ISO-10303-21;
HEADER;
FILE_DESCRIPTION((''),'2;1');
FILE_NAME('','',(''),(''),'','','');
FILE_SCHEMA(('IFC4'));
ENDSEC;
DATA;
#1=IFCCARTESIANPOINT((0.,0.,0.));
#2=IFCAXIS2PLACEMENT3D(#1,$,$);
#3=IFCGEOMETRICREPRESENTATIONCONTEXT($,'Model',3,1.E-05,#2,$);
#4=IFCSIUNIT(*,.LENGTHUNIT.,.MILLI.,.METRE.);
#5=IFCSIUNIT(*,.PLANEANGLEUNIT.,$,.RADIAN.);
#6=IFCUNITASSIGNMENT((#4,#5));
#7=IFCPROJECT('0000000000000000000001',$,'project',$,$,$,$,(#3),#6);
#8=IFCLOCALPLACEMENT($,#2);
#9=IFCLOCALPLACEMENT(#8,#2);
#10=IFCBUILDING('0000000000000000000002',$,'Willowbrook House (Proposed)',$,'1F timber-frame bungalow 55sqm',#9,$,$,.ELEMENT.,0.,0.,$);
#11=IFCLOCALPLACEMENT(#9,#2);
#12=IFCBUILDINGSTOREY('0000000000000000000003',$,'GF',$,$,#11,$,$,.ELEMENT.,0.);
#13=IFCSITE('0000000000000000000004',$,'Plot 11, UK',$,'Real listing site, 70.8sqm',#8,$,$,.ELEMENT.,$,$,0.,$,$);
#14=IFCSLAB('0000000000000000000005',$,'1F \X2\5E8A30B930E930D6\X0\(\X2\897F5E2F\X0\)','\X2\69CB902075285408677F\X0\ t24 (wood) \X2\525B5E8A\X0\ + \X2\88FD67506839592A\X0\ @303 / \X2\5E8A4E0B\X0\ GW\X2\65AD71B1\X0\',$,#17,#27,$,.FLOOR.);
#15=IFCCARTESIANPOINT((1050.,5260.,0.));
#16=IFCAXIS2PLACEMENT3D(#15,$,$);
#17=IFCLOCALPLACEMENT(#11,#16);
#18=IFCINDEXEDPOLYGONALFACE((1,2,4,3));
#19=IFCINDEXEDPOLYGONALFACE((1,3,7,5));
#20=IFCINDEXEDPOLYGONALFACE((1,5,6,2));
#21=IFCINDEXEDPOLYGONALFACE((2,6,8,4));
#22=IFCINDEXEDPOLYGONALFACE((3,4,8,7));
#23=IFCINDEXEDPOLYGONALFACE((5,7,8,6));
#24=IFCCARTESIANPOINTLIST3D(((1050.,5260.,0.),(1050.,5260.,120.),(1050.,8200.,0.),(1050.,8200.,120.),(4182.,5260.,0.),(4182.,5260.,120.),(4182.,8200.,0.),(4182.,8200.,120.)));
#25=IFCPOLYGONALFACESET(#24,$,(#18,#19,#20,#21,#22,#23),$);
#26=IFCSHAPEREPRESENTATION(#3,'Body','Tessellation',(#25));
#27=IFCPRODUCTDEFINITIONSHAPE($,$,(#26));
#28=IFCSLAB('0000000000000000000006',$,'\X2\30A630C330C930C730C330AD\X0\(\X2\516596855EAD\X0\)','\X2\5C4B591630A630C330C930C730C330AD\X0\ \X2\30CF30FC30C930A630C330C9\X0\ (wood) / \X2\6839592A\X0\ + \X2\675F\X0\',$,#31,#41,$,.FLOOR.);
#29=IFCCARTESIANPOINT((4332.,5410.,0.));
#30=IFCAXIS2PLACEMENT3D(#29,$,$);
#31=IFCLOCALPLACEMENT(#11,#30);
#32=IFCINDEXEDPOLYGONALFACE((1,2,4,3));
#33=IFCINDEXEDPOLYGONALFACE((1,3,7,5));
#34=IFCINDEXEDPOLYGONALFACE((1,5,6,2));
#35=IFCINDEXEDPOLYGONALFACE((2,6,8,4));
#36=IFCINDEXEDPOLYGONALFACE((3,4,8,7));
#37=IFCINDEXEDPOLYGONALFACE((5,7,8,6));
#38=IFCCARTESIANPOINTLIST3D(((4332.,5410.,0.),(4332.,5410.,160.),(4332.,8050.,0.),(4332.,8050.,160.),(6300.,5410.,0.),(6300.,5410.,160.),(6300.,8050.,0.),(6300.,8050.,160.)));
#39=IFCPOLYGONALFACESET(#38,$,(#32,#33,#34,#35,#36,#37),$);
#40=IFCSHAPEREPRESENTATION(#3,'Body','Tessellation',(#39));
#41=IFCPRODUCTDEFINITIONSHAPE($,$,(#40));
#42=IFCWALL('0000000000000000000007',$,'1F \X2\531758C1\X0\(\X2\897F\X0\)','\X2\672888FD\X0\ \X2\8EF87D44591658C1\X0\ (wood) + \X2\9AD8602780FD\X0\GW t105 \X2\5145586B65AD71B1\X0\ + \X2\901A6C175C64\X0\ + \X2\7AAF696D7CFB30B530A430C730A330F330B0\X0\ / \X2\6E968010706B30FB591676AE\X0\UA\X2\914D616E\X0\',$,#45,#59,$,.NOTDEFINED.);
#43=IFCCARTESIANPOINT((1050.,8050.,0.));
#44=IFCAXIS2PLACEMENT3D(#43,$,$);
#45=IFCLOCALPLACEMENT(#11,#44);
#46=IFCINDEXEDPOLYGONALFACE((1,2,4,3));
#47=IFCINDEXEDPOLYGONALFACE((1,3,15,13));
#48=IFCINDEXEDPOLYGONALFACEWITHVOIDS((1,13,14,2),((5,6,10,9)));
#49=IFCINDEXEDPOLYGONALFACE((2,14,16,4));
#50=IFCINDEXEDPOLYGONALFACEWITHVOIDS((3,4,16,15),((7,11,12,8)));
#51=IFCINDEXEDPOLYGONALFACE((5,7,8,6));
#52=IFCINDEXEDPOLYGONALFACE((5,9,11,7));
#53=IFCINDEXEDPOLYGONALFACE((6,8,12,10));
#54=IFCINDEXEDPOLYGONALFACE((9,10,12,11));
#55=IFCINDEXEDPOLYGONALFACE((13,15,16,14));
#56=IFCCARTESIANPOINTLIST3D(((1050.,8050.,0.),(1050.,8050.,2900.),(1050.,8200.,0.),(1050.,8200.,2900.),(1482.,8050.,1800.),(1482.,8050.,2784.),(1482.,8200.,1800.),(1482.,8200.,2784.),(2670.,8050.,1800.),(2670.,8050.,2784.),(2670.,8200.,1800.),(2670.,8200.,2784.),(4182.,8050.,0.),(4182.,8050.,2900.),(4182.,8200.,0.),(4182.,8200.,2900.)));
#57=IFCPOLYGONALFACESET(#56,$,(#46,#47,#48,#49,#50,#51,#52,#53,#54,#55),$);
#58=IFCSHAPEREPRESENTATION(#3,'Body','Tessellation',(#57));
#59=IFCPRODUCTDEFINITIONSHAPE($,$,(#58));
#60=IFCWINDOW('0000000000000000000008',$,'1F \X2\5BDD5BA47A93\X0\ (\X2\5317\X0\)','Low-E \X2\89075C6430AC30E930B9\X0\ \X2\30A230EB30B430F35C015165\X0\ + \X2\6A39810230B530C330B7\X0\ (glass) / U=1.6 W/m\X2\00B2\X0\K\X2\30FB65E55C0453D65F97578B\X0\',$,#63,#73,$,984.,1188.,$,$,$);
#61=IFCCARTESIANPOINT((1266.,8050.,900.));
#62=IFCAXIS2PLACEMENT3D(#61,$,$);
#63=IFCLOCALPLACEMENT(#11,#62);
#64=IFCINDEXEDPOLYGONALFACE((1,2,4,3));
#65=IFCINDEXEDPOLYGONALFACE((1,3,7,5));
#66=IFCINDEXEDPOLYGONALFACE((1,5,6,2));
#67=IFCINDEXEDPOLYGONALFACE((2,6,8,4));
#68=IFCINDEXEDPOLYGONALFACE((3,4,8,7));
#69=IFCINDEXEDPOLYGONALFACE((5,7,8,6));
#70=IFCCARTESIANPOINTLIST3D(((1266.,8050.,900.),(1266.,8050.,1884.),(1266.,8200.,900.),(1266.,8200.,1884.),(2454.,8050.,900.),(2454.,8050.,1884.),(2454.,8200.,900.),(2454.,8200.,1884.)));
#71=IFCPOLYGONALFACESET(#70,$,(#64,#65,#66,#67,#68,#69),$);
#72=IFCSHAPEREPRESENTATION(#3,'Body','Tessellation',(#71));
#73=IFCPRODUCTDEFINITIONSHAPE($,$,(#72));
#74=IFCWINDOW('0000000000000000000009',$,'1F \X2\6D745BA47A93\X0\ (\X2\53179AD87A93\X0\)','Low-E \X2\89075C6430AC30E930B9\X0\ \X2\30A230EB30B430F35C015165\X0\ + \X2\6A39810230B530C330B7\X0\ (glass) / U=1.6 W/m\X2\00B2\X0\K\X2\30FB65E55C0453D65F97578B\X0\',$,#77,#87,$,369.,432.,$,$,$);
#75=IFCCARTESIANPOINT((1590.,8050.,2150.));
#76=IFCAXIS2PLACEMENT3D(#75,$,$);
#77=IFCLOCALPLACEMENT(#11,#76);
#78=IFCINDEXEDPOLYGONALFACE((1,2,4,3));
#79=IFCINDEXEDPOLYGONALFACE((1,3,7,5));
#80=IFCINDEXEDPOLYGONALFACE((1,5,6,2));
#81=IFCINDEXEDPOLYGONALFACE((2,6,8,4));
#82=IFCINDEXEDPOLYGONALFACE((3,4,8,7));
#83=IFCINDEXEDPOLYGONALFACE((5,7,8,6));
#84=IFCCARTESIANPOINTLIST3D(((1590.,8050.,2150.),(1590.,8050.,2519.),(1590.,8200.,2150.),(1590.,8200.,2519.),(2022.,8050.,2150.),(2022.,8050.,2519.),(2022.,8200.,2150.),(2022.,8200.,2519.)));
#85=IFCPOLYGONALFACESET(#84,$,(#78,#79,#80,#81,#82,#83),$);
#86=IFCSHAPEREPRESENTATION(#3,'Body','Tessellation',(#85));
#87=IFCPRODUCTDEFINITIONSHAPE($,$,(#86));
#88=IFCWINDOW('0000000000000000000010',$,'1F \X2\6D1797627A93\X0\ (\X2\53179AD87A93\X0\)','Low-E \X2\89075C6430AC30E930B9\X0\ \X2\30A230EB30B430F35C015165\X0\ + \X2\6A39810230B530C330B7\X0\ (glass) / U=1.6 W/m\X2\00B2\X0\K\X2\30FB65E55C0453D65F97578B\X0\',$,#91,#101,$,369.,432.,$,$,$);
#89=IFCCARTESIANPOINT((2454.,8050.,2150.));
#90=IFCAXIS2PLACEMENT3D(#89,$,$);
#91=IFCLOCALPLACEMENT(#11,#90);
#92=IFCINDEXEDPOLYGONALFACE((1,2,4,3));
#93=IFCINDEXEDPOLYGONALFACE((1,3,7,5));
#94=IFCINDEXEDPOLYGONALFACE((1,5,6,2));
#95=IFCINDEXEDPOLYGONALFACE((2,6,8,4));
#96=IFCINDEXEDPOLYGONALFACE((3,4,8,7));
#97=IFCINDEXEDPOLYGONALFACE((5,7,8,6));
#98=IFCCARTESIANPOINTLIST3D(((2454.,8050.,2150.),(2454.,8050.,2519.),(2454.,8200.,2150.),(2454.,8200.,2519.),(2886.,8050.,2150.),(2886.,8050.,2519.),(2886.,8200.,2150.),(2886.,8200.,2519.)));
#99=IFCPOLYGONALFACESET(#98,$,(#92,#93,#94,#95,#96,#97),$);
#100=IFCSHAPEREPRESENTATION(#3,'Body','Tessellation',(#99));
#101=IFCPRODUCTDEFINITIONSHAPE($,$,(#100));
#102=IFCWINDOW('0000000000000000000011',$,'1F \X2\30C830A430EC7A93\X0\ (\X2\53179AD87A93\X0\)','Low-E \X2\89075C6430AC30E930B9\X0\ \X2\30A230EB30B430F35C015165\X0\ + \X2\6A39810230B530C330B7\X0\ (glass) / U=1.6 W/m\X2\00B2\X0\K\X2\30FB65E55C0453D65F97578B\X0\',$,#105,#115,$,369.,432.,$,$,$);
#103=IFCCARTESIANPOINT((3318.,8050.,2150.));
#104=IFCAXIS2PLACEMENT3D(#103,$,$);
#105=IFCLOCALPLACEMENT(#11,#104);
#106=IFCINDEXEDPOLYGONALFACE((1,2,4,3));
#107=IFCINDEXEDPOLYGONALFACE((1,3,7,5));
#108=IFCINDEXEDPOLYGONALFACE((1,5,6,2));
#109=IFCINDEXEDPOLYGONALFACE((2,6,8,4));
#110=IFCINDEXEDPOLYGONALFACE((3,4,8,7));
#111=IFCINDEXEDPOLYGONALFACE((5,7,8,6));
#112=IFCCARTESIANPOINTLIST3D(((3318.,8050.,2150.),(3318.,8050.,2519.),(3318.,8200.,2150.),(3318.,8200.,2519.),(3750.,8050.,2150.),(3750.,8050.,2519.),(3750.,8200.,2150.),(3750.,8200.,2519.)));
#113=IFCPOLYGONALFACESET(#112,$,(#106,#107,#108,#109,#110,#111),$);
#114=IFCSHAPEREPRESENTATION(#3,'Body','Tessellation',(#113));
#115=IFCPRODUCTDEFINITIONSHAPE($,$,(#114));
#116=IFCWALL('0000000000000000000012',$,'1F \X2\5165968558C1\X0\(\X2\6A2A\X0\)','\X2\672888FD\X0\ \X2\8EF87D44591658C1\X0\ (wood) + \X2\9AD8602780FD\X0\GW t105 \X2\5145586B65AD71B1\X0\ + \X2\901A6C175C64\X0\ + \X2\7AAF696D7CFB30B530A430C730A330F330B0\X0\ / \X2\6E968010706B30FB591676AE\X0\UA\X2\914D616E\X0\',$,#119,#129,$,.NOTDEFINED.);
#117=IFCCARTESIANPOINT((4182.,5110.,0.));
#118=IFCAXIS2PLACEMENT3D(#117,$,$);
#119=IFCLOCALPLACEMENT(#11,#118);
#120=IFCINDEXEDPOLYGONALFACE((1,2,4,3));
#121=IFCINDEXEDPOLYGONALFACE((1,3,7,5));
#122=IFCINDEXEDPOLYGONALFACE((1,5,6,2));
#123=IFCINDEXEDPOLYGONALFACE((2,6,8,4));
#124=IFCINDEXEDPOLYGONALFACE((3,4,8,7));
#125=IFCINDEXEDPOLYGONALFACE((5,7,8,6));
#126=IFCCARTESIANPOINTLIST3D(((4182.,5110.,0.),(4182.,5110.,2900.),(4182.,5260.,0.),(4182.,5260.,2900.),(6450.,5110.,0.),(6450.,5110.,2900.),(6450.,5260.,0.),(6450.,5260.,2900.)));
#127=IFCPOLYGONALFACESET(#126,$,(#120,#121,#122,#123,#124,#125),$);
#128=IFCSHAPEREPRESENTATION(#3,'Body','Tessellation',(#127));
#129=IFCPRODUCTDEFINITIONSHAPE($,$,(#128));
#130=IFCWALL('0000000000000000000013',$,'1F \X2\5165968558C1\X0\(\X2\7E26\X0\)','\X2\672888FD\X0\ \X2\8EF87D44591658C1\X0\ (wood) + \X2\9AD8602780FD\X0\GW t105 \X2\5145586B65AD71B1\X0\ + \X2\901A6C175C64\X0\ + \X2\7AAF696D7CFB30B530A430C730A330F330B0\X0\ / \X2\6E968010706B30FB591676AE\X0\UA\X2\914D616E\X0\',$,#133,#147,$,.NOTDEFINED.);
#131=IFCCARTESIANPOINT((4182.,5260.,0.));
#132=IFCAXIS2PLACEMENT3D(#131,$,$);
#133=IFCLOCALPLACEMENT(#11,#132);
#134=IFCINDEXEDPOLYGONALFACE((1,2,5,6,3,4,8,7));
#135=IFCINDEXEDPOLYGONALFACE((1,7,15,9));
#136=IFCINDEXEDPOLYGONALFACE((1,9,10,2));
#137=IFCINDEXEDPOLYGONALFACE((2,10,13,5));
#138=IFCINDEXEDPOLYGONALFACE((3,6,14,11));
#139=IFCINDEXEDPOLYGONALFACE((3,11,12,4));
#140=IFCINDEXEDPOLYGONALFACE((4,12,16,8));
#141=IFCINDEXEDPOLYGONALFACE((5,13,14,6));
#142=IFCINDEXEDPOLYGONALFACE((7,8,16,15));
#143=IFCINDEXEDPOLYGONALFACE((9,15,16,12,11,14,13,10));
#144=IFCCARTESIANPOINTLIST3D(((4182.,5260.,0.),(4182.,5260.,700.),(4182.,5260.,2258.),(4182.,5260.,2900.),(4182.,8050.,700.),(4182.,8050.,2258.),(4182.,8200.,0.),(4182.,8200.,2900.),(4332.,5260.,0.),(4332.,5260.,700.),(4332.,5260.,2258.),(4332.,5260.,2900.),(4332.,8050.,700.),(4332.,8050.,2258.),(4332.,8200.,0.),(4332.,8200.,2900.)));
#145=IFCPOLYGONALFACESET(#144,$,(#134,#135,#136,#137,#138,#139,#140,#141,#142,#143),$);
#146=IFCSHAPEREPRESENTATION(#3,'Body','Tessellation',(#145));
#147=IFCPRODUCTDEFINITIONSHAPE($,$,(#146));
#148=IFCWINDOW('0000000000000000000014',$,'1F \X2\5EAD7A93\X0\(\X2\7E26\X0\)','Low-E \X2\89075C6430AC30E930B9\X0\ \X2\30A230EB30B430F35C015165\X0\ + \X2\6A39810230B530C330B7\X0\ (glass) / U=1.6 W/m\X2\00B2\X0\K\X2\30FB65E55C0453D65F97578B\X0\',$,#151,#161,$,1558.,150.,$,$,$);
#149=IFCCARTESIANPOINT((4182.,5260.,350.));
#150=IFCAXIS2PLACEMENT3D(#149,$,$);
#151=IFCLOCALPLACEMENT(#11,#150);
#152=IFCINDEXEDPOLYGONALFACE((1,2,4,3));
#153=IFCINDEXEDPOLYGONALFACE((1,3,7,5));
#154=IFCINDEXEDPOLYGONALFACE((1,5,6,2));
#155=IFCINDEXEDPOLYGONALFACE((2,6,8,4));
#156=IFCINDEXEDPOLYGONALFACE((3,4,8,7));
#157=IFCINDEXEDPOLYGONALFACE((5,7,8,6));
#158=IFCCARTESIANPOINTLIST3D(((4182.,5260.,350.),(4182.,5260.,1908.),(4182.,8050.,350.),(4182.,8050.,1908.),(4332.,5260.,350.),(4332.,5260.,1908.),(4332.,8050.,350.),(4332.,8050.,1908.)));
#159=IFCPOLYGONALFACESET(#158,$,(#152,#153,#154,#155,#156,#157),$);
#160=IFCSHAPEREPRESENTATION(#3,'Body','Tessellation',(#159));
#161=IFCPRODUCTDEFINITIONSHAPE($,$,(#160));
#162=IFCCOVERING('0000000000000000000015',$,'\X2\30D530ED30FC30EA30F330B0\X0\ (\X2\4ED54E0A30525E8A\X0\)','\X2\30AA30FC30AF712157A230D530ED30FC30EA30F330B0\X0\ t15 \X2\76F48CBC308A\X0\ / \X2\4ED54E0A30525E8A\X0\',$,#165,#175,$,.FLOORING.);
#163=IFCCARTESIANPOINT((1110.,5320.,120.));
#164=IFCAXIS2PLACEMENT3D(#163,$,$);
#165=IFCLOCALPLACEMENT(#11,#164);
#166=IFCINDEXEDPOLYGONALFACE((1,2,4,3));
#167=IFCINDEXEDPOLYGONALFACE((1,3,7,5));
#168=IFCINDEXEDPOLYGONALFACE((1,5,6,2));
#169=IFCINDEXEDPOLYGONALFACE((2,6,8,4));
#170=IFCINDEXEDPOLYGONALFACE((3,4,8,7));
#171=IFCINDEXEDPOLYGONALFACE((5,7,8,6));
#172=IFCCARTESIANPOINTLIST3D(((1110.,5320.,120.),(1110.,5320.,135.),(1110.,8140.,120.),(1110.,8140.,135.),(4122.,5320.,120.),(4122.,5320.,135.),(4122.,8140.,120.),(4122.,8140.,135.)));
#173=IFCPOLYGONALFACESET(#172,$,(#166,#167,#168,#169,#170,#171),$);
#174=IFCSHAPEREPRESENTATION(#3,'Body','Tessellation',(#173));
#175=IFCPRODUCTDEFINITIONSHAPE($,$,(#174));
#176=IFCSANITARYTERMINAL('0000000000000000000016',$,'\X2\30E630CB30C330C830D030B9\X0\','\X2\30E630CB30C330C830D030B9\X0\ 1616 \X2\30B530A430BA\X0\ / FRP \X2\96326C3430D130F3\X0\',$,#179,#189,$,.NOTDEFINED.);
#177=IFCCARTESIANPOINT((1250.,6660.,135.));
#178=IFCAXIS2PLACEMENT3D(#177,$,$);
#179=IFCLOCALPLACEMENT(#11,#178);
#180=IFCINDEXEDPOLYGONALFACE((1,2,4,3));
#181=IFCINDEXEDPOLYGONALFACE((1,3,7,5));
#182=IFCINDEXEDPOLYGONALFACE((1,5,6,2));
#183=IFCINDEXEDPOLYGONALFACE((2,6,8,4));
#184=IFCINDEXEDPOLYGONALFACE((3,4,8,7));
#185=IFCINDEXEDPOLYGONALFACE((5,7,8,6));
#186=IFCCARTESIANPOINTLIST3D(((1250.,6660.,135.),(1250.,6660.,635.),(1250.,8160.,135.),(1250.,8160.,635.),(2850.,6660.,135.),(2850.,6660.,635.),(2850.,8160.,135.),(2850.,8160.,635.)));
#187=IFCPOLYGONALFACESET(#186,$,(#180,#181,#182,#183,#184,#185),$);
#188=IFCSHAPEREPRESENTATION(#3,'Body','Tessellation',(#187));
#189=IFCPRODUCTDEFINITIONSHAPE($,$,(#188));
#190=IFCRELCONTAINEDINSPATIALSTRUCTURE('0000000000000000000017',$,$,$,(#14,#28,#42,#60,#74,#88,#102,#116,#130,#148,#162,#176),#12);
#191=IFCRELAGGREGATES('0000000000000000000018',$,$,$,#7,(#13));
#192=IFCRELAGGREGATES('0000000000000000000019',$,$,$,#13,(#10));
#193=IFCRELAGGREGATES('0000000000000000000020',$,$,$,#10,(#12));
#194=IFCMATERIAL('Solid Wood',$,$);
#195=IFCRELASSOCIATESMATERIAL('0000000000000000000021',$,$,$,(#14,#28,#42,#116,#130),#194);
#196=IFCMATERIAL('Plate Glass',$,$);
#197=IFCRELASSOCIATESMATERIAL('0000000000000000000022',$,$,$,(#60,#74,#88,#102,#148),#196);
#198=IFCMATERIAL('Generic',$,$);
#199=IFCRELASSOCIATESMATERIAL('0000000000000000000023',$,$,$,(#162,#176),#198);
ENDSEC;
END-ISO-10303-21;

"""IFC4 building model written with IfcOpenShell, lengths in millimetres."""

from ifc_helpers import new_model, si_unit, frame, frame_2d, origin, place, context, project, spatial, rectangle, extrude, material, element, fill, save


model = new_model("IFC4")

# Units and contexts
model_context = context("Model", 3, precision=1e-05, world=origin())
ifc_project = project(units=[si_unit("LENGTHUNIT", "METRE", prefix="MILLI"), si_unit("PLANEANGLEUNIT", "RADIAN")], contexts=[model_context])

# Site, building, storey
site_placement = place(None, origin())
site = spatial("IfcSite", under=ifc_project, at=site_placement, Name="Plot 11, UK", ObjectType="Real listing site, 70.8sqm", CompositionType="ELEMENT", RefElevation=0.0)
building_placement = place(site_placement, origin())
building = spatial("IfcBuilding", under=site, at=building_placement, Name="Willowbrook House (Proposed)", ObjectType="1F timber-frame bungalow 55sqm", CompositionType="ELEMENT", ElevationOfRefHeight=0.0, ElevationOfTerrain=0.0)
storey_placement = place(building_placement, origin())
storey = spatial("IfcBuildingStorey", under=building, at=storey_placement, Name="GF", CompositionType="ELEMENT", Elevation=0.0)

# Slabs
ifc_material_1 = material(Name="Solid Wood")
slab_1_placement = place(storey_placement, frame((1050.0, 5260.0, 0.0)))
element("IfcSlab", 1, at=slab_1_placement, inside=storey, material=ifc_material_1, Name="1F 床スラブ(西帯)", Description="構造用合板 t24 (wood) 剛床 + 製材根太 @303 / 床下 GW断熱", PredefinedType="FLOOR", context=model_context, shape_type="SweptSolid", body=[
    extrude(rectangle(XDim=3132.0, YDim=2940.0, at=frame_2d((1566.0, 1470.0))), frame((1050.0, 5260.0, 0.0)), (0.0, 0.0, 1.0), 120.0),
])
slab_2_placement = place(storey_placement, frame((4332.0, 5410.0, 0.0)))
element("IfcSlab", 2, at=slab_2_placement, inside=storey, material=ifc_material_1, Name="ウッドデッキ(入隅庭)", Description="屋外ウッドデッキ ハードウッド (wood) / 根太 + 束", PredefinedType="FLOOR", context=model_context, shape_type="SweptSolid", body=[
    extrude(rectangle(XDim=1968.0, YDim=2640.0, at=frame_2d((984.0, 1320.0))), frame((4332.0, 5410.0, 0.0)), (0.0, 0.0, 1.0), 160.0),
])

# Wall, openings, windows
wall_1_placement = place(storey_placement, frame((1050.0, 8050.0, 0.0)))
wall_1 = element("IfcWall", 3, at=wall_1_placement, inside=storey, material=ifc_material_1, Name="1F 北壁(西)", Description="木製 軸組外壁 (wood) + 高性能GW t105 充填断熱 + 通気層 + 窯業系サイディング / 準耐火・外皮UA配慮", PredefinedType="NOTDEFINED", context=model_context, shape_type="SweptSolid", body=[
    extrude(rectangle(XDim=3132.0, YDim=150.0, at=frame_2d((1566.0, 75.0))), frame((1050.0, 8050.0, 0.0)), (0.0, 0.0, 1.0), 2900.0),
])
opening_1_placement = place(storey_placement, frame((1266.0, 8050.0, 900.0)))
opening_1 = element("IfcOpeningElement", 4, at=opening_1_placement, cuts=wall_1, PredefinedType="NOTDEFINED", context=model_context, shape_type="SweptSolid", body=[
    extrude(rectangle(XDim=1188.0, YDim=150.0, at=frame_2d((594.0, 75.0))), frame((1266.0, 8050.0, 900.0)), (0.0, 0.0, 1.0), 984.0),
])
opening_2_placement = place(storey_placement, frame((1590.0, 8050.0, 2150.0)))
opening_2 = element("IfcOpeningElement", 5, at=opening_2_placement, cuts=wall_1, PredefinedType="NOTDEFINED", context=model_context, shape_type="SweptSolid", body=[
    extrude(rectangle(XDim=432.0, YDim=150.0, at=frame_2d((216.0, 75.0))), frame((1590.0, 8050.0, 2150.0)), (0.0, 0.0, 1.0), 369.0),
])
opening_3_placement = place(storey_placement, frame((2454.0, 8050.0, 2150.0)))
opening_3 = element("IfcOpeningElement", 6, at=opening_3_placement, cuts=wall_1, PredefinedType="NOTDEFINED", context=model_context, shape_type="SweptSolid", body=[
    extrude(rectangle(XDim=432.0, YDim=150.0, at=frame_2d((216.0, 75.0))), frame((2454.0, 8050.0, 2150.0)), (0.0, 0.0, 1.0), 369.0),
])
opening_4_placement = place(storey_placement, frame((3318.0, 8050.0, 2150.0)))
opening_4 = element("IfcOpeningElement", 7, at=opening_4_placement, cuts=wall_1, PredefinedType="NOTDEFINED", context=model_context, shape_type="SweptSolid", body=[
    extrude(rectangle(XDim=432.0, YDim=150.0, at=frame_2d((216.0, 75.0))), frame((3318.0, 8050.0, 2150.0)), (0.0, 0.0, 1.0), 369.0),
])
ifc_material_2 = material(Name="Plate Glass")
window_1_placement = place(storey_placement, frame((1266.0, 8050.0, 900.0)))
window_1 = element("IfcWindow", 8, at=window_1_placement, inside=storey, material=ifc_material_2, Name="1F 寝室窓 (北)", Description="Low-E 複層ガラス アルゴン封入 + 樹脂サッシ (glass) / U=1.6 W/m²K・日射取得型", OverallHeight=984.0, OverallWidth=1188.0, context=model_context, shape_type="SweptSolid", body=[
    extrude(rectangle(XDim=1188.0, YDim=150.0, at=frame_2d((594.0, 75.0))), frame((1266.0, 8050.0, 900.0)), (0.0, 0.0, 1.0), 984.0),
])
fill(opening_1, window_1)
window_2_placement = place(storey_placement, frame((1590.0, 8050.0, 2150.0)))
window_2 = element("IfcWindow", 9, at=window_2_placement, inside=storey, material=ifc_material_2, Name="1F 浴室窓 (北高窓)", Description="Low-E 複層ガラス アルゴン封入 + 樹脂サッシ (glass) / U=1.6 W/m²K・日射取得型", OverallHeight=369.0, OverallWidth=432.0, context=model_context, shape_type="SweptSolid", body=[
    extrude(rectangle(XDim=432.0, YDim=150.0, at=frame_2d((216.0, 75.0))), frame((1590.0, 8050.0, 2150.0)), (0.0, 0.0, 1.0), 369.0),
])
fill(opening_2, window_2)
window_3_placement = place(storey_placement, frame((2454.0, 8050.0, 2150.0)))
window_3 = element("IfcWindow", 10, at=window_3_placement, inside=storey, material=ifc_material_2, Name="1F 洗面窓 (北高窓)", Description="Low-E 複層ガラス アルゴン封入 + 樹脂サッシ (glass) / U=1.6 W/m²K・日射取得型", OverallHeight=369.0, OverallWidth=432.0, context=model_context, shape_type="SweptSolid", body=[
    extrude(rectangle(XDim=432.0, YDim=150.0, at=frame_2d((216.0, 75.0))), frame((2454.0, 8050.0, 2150.0)), (0.0, 0.0, 1.0), 369.0),
])
fill(opening_3, window_3)
window_4_placement = place(storey_placement, frame((3318.0, 8050.0, 2150.0)))
window_4 = element("IfcWindow", 11, at=window_4_placement, inside=storey, material=ifc_material_2, Name="1F トイレ窓 (北高窓)", Description="Low-E 複層ガラス アルゴン封入 + 樹脂サッシ (glass) / U=1.6 W/m²K・日射取得型", OverallHeight=369.0, OverallWidth=432.0, context=model_context, shape_type="SweptSolid", body=[
    extrude(rectangle(XDim=432.0, YDim=150.0, at=frame_2d((216.0, 75.0))), frame((3318.0, 8050.0, 2150.0)), (0.0, 0.0, 1.0), 369.0),
])
fill(opening_4, window_4)

# Wall
wall_2_placement = place(storey_placement, frame((4182.0, 5110.0, 0.0)))
element("IfcWall", 12, at=wall_2_placement, inside=storey, material=ifc_material_1, Name="1F 入隅壁(横)", Description="木製 軸組外壁 (wood) + 高性能GW t105 充填断熱 + 通気層 + 窯業系サイディング / 準耐火・外皮UA配慮", PredefinedType="NOTDEFINED", context=model_context, shape_type="SweptSolid", body=[
    extrude(rectangle(XDim=2268.0, YDim=150.0, at=frame_2d((1134.0, 75.0))), frame((4182.0, 5110.0, 0.0)), (0.0, 0.0, 1.0), 2900.0),
])

# Wall, opening, window
wall_3_placement = place(storey_placement, frame((4182.0, 5260.0, 0.0)))
wall_3 = element("IfcWall", 13, at=wall_3_placement, inside=storey, material=ifc_material_1, Name="1F 入隅壁(縦)", Description="木製 軸組外壁 (wood) + 高性能GW t105 充填断熱 + 通気層 + 窯業系サイディング / 準耐火・外皮UA配慮", PredefinedType="NOTDEFINED", context=model_context, shape_type="SweptSolid", body=[
    extrude(rectangle(XDim=150.0, YDim=2940.0, at=frame_2d((75.0, 1470.0))), frame((4182.0, 5260.0, 0.0)), (0.0, 0.0, 1.0), 2900.0),
])
opening_5_placement = place(storey_placement, frame((4182.0, 5260.0, 350.0)))
opening_5 = element("IfcOpeningElement", 14, at=opening_5_placement, cuts=wall_3, PredefinedType="NOTDEFINED", context=model_context, shape_type="SweptSolid", body=[
    extrude(rectangle(XDim=150.0, YDim=2790.0, at=frame_2d((75.0, 1395.0))), frame((4182.0, 5260.0, 350.0)), (0.0, 0.0, 1.0), 1558.0),
])
window_5_placement = place(storey_placement, frame((4182.0, 5260.0, 350.0)))
window_5 = element("IfcWindow", 15, at=window_5_placement, inside=storey, material=ifc_material_2, Name="1F 庭窓(縦)", Description="Low-E 複層ガラス アルゴン封入 + 樹脂サッシ (glass) / U=1.6 W/m²K・日射取得型", OverallHeight=1558.0, OverallWidth=150.0, context=model_context, shape_type="SweptSolid", body=[
    extrude(rectangle(XDim=150.0, YDim=2790.0, at=frame_2d((75.0, 1395.0))), frame((4182.0, 5260.0, 350.0)), (0.0, 0.0, 1.0), 1558.0),
])
fill(opening_5, window_5)

# Covering
ifc_material_3 = material(Name="Generic")
covering_placement = place(storey_placement, frame((1110.0, 5320.0, 120.0)))
element("IfcCovering", 16, at=covering_placement, inside=storey, material=ifc_material_3, Name="フローリング (仕上げ床)", Description="オーク無垢フローリング t15 直貼り / 仕上げ床", PredefinedType="FLOORING", context=model_context, shape_type="SweptSolid", body=[
    extrude(rectangle(XDim=3012.0, YDim=2820.0, at=frame_2d((1506.0, 1410.0))), frame((1110.0, 5320.0, 120.0)), (0.0, 0.0, 1.0), 15.0),
])

# Sanitary terminal
sanitary_terminal_1_placement = place(storey_placement, frame((1250.0, 6660.0, 135.0)))
element("IfcSanitaryTerminal", 17, at=sanitary_terminal_1_placement, inside=storey, material=ifc_material_3, Name="ユニットバス", Description="ユニットバス 1616 サイズ / FRP 防水パン", PredefinedType="NOTDEFINED", context=model_context, shape_type="SweptSolid", body=[
    extrude(rectangle(XDim=1600.0, YDim=1500.0, at=frame_2d((800.0, 750.0))), frame((1250.0, 6660.0, 135.0)), (0.0, 0.0, 1.0), 500.0),
])

save(model, "model.ifc")
